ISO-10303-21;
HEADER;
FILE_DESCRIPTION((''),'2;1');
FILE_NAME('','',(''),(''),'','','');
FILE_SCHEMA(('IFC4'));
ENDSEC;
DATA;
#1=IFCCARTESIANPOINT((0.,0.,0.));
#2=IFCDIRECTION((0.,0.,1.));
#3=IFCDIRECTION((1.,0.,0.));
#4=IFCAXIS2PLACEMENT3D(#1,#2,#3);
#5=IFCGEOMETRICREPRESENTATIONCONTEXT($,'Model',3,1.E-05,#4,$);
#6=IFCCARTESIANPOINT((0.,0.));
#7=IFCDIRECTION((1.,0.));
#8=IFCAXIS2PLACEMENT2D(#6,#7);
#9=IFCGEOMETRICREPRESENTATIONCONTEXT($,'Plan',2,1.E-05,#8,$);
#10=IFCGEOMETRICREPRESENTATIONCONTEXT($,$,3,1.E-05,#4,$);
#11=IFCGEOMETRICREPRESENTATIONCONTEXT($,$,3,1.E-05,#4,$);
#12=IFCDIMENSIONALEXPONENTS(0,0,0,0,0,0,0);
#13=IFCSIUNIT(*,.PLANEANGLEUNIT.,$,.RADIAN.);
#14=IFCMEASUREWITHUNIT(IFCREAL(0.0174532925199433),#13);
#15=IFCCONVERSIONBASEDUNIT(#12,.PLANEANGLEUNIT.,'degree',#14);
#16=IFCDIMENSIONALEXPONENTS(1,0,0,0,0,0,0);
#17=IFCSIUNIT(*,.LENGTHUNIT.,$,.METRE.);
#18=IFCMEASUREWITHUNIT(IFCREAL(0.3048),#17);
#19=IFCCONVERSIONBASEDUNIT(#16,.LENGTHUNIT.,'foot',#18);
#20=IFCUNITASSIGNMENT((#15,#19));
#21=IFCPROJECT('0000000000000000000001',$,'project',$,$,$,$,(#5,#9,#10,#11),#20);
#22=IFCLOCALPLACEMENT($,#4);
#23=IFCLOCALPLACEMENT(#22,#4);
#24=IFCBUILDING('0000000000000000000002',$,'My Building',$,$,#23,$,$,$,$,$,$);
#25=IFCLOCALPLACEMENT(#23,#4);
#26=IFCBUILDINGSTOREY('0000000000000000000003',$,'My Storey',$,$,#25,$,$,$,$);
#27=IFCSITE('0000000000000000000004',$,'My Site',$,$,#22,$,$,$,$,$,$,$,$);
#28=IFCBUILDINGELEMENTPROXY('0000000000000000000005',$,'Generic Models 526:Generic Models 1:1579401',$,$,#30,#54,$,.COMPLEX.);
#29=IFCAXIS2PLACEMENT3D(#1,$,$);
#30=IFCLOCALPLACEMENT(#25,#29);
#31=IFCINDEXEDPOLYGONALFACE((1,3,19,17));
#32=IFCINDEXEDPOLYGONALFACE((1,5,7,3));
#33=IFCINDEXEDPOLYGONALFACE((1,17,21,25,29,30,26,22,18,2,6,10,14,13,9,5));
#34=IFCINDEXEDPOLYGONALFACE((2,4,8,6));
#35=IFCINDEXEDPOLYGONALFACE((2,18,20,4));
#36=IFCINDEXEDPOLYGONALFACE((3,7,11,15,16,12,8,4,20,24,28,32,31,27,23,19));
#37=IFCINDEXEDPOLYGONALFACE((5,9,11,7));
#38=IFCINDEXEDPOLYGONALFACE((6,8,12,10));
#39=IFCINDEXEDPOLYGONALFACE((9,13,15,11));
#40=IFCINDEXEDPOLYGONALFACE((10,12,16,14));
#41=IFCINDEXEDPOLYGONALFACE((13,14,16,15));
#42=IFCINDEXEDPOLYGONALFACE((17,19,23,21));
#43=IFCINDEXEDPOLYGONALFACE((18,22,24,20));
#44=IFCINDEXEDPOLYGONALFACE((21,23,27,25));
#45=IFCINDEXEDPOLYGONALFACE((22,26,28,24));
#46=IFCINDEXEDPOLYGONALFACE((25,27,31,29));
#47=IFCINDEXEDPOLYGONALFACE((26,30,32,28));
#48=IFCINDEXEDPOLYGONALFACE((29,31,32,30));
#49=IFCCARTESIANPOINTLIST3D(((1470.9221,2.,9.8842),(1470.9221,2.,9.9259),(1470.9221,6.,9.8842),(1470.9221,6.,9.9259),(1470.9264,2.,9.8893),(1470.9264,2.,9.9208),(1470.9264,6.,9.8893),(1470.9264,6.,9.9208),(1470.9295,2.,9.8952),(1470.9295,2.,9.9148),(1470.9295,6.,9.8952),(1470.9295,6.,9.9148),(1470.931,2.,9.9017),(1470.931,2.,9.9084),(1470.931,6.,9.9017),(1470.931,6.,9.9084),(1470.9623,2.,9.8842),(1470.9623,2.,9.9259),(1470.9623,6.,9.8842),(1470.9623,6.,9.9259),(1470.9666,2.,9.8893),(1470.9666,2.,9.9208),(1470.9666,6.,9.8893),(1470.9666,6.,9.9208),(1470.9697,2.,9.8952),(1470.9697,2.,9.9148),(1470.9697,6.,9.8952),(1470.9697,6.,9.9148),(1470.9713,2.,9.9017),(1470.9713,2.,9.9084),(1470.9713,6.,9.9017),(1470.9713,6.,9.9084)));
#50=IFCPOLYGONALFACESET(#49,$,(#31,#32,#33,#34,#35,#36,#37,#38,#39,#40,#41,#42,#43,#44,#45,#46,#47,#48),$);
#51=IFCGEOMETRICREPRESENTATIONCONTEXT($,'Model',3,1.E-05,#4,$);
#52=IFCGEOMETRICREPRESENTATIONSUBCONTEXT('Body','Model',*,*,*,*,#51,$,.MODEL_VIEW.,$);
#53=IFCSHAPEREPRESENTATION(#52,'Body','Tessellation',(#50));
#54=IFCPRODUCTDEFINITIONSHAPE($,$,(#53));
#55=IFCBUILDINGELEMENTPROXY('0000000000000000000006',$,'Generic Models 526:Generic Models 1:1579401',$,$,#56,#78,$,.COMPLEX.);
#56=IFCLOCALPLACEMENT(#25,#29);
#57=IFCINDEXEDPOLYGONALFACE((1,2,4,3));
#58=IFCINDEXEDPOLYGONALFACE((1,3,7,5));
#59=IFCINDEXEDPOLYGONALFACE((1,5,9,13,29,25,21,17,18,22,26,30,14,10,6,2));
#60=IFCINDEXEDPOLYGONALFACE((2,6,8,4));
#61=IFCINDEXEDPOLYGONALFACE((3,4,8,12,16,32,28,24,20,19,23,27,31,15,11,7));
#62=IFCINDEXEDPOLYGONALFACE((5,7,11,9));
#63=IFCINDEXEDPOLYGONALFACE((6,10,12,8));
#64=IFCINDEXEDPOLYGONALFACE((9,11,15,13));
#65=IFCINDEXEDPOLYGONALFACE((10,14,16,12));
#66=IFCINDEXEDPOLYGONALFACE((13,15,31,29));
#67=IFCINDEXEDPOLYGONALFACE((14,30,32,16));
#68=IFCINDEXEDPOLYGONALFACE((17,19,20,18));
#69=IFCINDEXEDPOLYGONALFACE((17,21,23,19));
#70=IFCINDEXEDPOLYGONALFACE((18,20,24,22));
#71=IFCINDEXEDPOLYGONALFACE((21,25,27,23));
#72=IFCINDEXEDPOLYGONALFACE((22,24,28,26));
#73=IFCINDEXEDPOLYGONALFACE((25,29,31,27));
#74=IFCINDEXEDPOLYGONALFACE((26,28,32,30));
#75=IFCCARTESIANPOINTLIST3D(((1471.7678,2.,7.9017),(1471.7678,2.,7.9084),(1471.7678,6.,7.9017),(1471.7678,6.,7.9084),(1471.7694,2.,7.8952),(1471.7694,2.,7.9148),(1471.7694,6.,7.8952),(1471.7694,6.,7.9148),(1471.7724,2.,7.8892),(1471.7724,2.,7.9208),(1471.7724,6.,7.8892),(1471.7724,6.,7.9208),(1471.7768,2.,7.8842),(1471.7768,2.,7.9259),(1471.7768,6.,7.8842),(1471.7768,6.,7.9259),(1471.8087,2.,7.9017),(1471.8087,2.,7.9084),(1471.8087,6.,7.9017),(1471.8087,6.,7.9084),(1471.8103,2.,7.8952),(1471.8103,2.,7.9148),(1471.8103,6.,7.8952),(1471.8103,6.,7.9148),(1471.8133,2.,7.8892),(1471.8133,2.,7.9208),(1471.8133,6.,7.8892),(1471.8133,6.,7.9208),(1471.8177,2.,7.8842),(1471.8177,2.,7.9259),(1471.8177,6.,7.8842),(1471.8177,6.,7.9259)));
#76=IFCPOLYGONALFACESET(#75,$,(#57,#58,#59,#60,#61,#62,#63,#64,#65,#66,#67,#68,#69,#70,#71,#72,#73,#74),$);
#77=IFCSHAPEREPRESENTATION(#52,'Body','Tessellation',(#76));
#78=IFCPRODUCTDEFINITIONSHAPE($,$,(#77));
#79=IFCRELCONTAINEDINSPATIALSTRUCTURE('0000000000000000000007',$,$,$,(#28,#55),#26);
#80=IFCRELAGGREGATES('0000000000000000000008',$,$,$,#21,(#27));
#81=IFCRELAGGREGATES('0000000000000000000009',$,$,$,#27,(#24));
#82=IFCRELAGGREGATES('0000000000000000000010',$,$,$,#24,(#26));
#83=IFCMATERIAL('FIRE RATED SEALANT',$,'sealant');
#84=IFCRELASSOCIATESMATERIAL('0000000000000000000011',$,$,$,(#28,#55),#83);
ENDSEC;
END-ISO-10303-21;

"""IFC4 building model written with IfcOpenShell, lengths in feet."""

from ifc_helpers import new_model, entity, si_unit, converted_unit, frame, origin_with_axes, origin_2d_with_axis, place, context, subcontext, project, spatial, line, indexed_curve, outline, extrude, material, element, save


model = new_model("IFC4")

# Units and contexts
model_context_1 = context("Model", 3, precision=1e-05, world=origin_with_axes())
plan_context = context("Plan", 2, precision=1e-05, world=origin_2d_with_axis())
model_context_2 = context("Model", 3, precision=1e-05, world=origin_with_axes())
context_of_model_1 = context(None, 3, precision=1e-05, world=origin_with_axes())
context_of_model_2 = context(None, 3, precision=1e-05, world=origin_with_axes())
body_context_1 = subcontext(model_context_2, "Body", "Model", "MODEL_VIEW")
ifc_project = project(units=[converted_unit("PLANEANGLEUNIT", "degree", entity("IfcReal", 0.0174532925199433), si_unit("PLANEANGLEUNIT", "RADIAN"), dimensions=[0, 0, 0, 0, 0, 0, 0]), converted_unit("LENGTHUNIT", "foot", entity("IfcReal", 0.3048), si_unit("LENGTHUNIT", "METRE"), dimensions=[1, 0, 0, 0, 0, 0, 0])], contexts=[model_context_1, plan_context, context_of_model_1, context_of_model_2])

# Site, building, storey
site_placement = place(None, origin_with_axes())
site = spatial("IfcSite", under=ifc_project, at=site_placement, Name="My Site")
building_placement = place(site_placement, origin_with_axes())
building = spatial("IfcBuilding", under=site, at=building_placement, Name="My Building")
storey_placement = place(building_placement, origin_with_axes())
storey = spatial("IfcBuildingStorey", under=building, at=storey_placement, Name="My Storey")

# Building element proxies
ifc_material_1 = material(Name="FIRE RATED SEALANT", Category="sealant")
proxy_1_placement = place(storey_placement, frame((1470.922, 6.0, 9.8842), z_axis=(0.0, -1.0, 0.0), x_axis=(0.0, 0.0, 1.0)))
element("IfcBuildingElementProxy", 1, at=proxy_1_placement, inside=storey, material=ifc_material_1, Name="Generic Models 526:Generic Models 1:1579401", PredefinedType="COMPLEX", context=body_context_1, shape_type="SweptSolid", body=[
    extrude(outline(indexed_curve([(0.0285, 0.0001), (0.0278, -0.0065), (0.0255, -0.0128), (0.0219, -0.0184), (0.017, -0.023), (0.0112, -0.0263), (0.0048, -0.0281), (-0.0019, -0.0284), (-0.0294, 0.0009), (-0.0228, 0.0012), (-0.0163, 0.0031), (-0.0105, 0.0064), (-0.0057, 0.0109), (-0.002, 0.0165), (0.0002, 0.0228), (0.001, 0.0294)], segments=[line(12, 11), line(11, 10), line(10, 9), line(9, 8), line(8, 7), line(7, 6), line(6, 5), line(5, 4), line(4, 3), line(3, 2), line(2, 1), line(1, 16), line(16, 15), line(15, 14), line(14, 13), line(13, 12)], self_intersect=False)), frame((0.0208, -0.0208, 0.0), z_axis=(0.0, 0.0, -1.0), x_axis=(-0.729168, -0.684334, 0.0)), (0.0, 0.0, -1.0), 4.0),
])
proxy_2_placement = place(storey_placement, frame((1471.8177, 6.0, 7.9259), z_axis=(0.0, -1.0, 0.0), x_axis=(0.0, 0.0, -1.0)))
element("IfcBuildingElementProxy", 2, at=proxy_2_placement, inside=storey, material=ifc_material_1, Name="Generic Models 526:Generic Models 1:1579401", PredefinedType="COMPLEX", context=body_context_1, shape_type="SweptSolid", body=[
    extrude(outline(indexed_curve([(0.029, -0.0004), (0.0282, -0.007), (0.026, -0.0133), (0.0223, -0.0189), (0.0175, -0.0235), (0.0117, -0.0268), (0.0052, -0.0286), (-0.0014, -0.0289), (-0.0294, 0.0009), (-0.0228, 0.0012), (-0.0163, 0.0031), (-0.0105, 0.0064), (-0.0057, 0.0109), (-0.002, 0.0165), (0.0002, 0.0228), (0.001, 0.0294)], segments=[line(2, 1), line(1, 16), line(16, 15), line(15, 14), line(14, 13), line(13, 12), line(12, 11), line(11, 10), line(10, 9), line(9, 8), line(8, 7), line(7, 6), line(6, 5), line(5, 4), line(4, 3), line(3, 2)], self_intersect=False)), frame((0.0208, -0.0208, 0.0), z_axis=(0.0, 0.0, -1.0), x_axis=(-0.729168, -0.684334, 0.0)), (0.0, 0.0, -1.0), 4.0),
])

save(model, "model.ifc")
